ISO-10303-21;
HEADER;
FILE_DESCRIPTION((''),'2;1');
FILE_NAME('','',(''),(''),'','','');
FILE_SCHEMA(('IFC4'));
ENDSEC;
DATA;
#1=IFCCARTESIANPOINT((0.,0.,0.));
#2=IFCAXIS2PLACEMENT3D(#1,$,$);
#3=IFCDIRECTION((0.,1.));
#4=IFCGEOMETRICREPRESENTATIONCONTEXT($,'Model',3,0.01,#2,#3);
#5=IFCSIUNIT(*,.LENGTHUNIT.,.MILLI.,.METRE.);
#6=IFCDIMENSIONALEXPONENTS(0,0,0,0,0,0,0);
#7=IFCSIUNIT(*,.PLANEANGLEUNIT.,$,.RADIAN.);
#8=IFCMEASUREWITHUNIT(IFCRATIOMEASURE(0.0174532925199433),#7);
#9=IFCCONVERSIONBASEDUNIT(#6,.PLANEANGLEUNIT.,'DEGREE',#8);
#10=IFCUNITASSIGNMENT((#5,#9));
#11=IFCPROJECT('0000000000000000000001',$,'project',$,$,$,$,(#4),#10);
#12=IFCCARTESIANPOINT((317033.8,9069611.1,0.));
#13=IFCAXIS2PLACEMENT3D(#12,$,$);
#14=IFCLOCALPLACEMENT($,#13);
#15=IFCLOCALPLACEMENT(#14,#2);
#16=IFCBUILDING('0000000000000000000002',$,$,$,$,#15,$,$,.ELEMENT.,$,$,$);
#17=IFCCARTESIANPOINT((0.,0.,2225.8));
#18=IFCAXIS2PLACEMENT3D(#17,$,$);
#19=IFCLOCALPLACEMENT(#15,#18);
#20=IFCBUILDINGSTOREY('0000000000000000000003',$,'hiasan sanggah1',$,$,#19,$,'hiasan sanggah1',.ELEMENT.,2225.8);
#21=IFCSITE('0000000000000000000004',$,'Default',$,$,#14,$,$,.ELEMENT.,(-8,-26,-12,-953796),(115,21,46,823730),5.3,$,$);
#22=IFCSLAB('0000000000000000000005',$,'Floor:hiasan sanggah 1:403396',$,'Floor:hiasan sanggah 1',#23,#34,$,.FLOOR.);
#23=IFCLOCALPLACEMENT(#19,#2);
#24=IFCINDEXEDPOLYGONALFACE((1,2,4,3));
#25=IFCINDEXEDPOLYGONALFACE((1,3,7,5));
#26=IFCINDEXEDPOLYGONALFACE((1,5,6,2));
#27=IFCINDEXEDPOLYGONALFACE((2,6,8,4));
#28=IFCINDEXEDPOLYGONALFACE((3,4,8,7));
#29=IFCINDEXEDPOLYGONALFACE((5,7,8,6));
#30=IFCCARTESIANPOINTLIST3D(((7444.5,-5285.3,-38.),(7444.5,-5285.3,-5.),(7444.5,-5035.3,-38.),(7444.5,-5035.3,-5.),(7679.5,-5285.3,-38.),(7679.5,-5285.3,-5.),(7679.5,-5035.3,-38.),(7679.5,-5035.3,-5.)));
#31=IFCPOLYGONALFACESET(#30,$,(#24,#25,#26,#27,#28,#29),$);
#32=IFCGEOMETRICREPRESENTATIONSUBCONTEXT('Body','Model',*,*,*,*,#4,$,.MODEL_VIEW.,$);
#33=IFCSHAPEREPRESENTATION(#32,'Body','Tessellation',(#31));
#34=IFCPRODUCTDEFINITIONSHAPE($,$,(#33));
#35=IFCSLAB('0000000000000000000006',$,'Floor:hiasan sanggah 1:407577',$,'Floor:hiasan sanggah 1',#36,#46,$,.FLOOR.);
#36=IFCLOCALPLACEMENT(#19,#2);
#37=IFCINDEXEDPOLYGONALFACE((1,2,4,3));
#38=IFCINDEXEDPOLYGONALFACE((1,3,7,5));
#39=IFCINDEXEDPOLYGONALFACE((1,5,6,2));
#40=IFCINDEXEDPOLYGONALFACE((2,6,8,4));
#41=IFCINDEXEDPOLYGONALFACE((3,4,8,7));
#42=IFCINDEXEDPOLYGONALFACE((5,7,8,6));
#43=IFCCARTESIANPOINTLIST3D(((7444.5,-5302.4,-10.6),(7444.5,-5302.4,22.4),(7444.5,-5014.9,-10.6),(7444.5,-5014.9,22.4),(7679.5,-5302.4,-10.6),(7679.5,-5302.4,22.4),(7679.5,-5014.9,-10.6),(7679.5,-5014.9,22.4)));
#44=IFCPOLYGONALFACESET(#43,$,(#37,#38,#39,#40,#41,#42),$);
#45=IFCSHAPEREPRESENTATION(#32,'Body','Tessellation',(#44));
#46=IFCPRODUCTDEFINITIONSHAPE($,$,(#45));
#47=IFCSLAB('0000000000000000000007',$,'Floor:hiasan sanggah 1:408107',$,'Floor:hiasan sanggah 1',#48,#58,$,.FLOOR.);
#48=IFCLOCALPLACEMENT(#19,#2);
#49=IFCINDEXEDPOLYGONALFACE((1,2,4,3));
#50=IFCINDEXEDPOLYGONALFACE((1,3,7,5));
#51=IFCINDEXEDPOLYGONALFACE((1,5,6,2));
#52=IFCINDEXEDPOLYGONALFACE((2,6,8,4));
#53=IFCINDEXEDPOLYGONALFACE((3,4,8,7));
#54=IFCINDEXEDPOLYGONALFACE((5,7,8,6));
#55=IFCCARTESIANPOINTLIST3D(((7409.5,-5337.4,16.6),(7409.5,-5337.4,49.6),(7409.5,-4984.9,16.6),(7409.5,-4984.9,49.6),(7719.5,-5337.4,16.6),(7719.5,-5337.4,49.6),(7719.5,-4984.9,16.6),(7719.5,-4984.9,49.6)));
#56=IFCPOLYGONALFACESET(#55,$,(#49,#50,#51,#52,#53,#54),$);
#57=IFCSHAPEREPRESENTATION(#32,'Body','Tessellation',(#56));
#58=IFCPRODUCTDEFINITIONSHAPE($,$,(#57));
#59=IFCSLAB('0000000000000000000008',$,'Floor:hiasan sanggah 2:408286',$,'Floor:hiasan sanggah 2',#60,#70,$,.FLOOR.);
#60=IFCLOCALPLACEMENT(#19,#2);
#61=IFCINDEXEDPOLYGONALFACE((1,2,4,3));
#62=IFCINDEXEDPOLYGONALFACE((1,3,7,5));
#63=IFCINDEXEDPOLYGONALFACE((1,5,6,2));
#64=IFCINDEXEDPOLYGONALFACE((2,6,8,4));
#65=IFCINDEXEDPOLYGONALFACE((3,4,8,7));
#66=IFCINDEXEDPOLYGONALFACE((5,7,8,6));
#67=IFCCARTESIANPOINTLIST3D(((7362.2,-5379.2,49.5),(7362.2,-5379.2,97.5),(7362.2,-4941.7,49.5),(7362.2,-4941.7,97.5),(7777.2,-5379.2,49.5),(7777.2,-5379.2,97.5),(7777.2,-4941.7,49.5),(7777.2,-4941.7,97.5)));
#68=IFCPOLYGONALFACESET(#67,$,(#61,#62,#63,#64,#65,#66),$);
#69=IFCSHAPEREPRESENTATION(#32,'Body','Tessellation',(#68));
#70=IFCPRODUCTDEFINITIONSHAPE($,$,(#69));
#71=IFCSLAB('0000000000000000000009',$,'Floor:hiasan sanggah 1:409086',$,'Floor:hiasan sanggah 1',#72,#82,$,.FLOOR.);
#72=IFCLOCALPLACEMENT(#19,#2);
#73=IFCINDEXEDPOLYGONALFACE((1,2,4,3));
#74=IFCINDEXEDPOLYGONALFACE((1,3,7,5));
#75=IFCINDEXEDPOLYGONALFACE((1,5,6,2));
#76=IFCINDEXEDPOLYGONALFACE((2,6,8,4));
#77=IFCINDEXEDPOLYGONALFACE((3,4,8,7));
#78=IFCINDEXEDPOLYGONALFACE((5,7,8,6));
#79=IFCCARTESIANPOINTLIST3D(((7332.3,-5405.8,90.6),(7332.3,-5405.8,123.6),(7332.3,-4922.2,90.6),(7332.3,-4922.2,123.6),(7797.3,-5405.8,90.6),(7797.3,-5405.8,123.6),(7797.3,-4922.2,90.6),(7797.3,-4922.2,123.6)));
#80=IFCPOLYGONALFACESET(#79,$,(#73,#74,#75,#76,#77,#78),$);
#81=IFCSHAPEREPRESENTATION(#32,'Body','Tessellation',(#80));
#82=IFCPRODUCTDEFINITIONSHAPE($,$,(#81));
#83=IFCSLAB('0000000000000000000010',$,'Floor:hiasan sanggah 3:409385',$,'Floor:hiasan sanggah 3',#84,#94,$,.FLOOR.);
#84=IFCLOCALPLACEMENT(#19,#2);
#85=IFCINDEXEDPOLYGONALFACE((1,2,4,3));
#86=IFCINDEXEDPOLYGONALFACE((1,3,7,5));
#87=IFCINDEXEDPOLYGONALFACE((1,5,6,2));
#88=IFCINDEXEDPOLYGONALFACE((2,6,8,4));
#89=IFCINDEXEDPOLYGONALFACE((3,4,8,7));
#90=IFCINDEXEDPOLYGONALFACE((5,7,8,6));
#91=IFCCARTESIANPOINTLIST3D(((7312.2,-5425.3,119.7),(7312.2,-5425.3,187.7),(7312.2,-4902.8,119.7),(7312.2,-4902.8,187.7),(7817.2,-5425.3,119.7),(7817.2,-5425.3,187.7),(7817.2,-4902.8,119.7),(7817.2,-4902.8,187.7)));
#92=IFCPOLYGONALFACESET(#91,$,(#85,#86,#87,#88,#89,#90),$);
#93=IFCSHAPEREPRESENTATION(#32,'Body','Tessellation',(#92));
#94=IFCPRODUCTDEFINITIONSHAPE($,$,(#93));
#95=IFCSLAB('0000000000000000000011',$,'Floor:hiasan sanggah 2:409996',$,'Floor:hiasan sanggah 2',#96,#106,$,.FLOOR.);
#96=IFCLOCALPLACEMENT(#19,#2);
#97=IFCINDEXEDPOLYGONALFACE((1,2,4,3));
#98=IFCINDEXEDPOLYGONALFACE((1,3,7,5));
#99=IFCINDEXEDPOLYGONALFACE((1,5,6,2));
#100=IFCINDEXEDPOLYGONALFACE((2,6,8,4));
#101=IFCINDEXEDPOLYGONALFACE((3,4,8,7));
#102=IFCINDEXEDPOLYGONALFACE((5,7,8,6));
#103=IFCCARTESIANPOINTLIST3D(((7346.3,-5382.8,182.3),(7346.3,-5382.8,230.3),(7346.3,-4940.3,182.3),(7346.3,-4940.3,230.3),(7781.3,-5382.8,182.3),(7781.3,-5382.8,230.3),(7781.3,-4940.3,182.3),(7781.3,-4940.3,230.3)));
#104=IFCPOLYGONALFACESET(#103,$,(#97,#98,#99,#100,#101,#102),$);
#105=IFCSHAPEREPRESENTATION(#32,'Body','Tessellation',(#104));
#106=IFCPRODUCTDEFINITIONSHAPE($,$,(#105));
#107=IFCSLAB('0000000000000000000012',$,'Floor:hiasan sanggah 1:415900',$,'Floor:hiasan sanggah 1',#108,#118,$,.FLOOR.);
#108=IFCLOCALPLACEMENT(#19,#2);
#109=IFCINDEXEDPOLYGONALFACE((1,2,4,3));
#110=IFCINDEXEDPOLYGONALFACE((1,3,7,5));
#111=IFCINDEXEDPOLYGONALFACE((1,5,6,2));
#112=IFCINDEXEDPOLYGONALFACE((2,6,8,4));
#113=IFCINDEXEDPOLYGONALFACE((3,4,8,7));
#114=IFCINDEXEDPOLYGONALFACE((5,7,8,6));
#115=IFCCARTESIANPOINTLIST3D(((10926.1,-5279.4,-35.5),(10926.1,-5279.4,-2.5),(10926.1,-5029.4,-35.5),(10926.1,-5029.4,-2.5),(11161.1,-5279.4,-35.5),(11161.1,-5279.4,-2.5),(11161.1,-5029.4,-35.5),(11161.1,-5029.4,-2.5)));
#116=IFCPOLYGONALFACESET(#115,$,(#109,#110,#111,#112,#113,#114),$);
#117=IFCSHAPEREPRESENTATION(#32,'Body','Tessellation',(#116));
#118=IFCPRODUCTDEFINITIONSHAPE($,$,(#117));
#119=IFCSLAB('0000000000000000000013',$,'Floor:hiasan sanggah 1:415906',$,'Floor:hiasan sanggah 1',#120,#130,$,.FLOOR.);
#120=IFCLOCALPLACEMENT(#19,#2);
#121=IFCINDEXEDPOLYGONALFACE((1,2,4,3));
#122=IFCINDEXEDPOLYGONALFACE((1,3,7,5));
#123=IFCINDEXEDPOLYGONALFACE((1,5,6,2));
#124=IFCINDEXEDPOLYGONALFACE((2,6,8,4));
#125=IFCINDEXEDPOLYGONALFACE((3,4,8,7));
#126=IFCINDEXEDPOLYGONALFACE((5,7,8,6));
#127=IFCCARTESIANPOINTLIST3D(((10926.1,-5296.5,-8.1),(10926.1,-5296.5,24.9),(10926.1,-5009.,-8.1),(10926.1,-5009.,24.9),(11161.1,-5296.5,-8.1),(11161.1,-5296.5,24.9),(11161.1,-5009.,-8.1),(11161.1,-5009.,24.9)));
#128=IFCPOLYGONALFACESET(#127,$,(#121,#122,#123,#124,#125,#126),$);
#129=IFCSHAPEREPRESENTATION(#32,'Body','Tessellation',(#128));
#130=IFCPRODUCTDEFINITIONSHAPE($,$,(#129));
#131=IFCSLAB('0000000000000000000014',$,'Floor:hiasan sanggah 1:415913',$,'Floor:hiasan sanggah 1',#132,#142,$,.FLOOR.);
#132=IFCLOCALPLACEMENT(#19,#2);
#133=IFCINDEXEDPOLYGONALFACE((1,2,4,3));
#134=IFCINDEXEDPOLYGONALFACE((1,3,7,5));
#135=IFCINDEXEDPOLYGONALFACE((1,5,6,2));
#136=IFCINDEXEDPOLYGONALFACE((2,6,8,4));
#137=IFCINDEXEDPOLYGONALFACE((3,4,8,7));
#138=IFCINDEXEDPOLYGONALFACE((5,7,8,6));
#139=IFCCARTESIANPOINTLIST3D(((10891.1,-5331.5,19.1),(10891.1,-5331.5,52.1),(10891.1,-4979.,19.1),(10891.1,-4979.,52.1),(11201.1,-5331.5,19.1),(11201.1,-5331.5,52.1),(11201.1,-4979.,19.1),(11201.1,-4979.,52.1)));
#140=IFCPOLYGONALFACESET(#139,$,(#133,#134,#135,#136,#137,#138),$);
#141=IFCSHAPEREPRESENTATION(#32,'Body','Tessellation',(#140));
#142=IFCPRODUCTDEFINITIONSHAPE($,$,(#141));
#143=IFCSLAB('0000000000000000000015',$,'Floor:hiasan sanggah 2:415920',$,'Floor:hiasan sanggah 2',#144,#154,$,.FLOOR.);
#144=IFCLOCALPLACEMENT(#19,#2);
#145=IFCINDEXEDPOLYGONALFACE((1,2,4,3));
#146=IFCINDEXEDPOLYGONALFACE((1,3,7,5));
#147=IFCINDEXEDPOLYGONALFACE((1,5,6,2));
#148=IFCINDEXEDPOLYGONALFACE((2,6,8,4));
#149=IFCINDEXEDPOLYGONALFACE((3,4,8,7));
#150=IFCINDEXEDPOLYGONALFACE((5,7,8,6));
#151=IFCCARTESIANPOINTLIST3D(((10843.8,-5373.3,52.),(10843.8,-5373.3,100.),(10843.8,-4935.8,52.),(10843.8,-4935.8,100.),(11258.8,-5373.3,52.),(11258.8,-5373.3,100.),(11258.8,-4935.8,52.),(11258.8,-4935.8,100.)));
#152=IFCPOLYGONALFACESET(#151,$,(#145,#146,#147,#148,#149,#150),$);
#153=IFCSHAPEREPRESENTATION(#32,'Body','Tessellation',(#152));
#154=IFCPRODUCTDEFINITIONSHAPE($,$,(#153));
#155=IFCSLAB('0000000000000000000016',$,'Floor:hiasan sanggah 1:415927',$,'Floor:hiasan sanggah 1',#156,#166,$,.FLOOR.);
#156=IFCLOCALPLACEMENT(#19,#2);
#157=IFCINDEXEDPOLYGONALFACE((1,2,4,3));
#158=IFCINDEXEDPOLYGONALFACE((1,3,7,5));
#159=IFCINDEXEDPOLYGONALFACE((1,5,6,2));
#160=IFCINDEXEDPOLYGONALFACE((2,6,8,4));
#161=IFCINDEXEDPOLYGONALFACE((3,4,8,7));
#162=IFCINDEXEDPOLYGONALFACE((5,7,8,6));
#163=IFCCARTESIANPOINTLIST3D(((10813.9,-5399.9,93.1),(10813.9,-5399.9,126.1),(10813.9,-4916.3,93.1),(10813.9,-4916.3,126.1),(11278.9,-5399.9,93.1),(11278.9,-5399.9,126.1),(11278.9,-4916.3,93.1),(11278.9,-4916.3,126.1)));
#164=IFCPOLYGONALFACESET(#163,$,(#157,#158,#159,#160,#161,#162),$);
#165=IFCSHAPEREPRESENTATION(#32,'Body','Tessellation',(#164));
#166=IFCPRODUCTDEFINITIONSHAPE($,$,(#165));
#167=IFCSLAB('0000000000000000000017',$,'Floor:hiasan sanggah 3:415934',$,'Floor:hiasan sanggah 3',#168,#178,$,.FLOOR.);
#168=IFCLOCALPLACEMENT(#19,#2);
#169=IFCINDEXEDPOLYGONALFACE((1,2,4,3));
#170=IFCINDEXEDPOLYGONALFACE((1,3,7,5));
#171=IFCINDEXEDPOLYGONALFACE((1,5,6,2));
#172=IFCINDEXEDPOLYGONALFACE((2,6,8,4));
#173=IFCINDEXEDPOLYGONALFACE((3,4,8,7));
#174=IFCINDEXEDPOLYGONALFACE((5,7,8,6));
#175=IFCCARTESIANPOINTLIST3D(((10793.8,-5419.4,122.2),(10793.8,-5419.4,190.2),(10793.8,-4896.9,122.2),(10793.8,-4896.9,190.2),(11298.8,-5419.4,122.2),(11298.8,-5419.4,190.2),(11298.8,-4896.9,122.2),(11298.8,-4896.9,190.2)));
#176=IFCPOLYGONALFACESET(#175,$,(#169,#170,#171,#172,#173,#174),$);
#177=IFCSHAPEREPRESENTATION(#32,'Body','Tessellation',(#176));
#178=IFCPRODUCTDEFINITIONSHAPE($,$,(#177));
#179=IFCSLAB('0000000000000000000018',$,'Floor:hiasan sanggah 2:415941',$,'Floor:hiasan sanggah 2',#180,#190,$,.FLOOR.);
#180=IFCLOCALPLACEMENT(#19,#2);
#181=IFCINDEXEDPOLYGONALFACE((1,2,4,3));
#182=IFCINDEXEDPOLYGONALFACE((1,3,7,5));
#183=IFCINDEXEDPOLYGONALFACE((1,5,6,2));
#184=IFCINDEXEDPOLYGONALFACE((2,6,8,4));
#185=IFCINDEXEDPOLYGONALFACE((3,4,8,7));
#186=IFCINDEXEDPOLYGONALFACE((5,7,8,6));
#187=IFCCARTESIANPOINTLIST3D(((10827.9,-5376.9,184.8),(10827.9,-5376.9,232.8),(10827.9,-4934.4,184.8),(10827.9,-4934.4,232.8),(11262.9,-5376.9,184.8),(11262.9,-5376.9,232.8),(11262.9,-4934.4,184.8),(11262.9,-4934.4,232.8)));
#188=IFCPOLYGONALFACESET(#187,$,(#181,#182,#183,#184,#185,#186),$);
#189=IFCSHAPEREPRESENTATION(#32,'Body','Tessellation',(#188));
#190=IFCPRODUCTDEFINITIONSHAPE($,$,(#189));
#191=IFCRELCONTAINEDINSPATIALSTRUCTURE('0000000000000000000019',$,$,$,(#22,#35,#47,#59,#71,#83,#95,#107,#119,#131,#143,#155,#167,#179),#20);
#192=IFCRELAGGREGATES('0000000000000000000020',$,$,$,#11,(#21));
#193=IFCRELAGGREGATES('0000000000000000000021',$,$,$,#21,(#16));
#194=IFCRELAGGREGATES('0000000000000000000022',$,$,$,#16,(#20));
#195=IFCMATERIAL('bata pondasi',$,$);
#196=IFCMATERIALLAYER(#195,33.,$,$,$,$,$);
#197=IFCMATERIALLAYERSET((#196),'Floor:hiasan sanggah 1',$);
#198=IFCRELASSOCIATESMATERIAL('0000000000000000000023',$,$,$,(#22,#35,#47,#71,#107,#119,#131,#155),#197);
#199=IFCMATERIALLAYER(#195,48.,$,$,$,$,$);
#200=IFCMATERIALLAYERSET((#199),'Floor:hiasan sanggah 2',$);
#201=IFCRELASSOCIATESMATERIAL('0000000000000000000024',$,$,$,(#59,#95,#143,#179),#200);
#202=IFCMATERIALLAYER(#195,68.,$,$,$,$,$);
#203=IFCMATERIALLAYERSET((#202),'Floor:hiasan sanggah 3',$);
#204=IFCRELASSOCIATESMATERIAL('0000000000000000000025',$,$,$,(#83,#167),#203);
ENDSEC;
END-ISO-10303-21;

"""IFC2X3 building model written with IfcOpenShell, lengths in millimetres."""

from ifc_helpers import new_model, entity, si_unit, converted_unit, direction, frame, frame_2d, origin, origin_2d_with_axis, place, context, subcontext, project, spatial, rectangle, extrude, material, layer, layer_set, layer_usage, element, save


model = new_model("IFC2X3")

# Units and contexts
model_context = context("Model", 3, precision=0.01, world=origin(), true_north=direction((0.0, 1.0)))
body_context = subcontext(model_context, "Body", "Model", "MODEL_VIEW")
ifc_project = project(units=[si_unit("LENGTHUNIT", "METRE", prefix="MILLI"), converted_unit("PLANEANGLEUNIT", "DEGREE", entity("IfcRatioMeasure", 0.0174532925199433), si_unit("PLANEANGLEUNIT", "RADIAN"), dimensions=[0, 0, 0, 0, 0, 0, 0])], contexts=[model_context])

# Site, building, storey
site_placement = place(None, frame((317033.8, 9069611.1, 0.0)))
site = spatial("IfcSite", under=ifc_project, at=site_placement, Name="Default", CompositionType="ELEMENT", RefLatitude=(-8, -26, -12, -953796), RefLongitude=(115, 21, 46, 823730), RefElevation=5.3)
building_placement = place(site_placement, origin())
building = spatial("IfcBuilding", under=site, at=building_placement, CompositionType="ELEMENT")
storey_placement = place(building_placement, frame((0.0, 0.0, 2225.8)))
storey = spatial("IfcBuildingStorey", under=building, at=storey_placement, Name="hiasan sanggah1", LongName="hiasan sanggah1", CompositionType="ELEMENT", Elevation=2225.8)

# Slabs
ifc_material = material(Name="bata pondasi")
ifc_layer_1 = layer(ifc_material, 33.0)
ifc_layer_set_1 = layer_set([ifc_layer_1], Name="Floor:hiasan sanggah 1")
ifc_layer_usage_1 = layer_usage(ifc_layer_set_1, "AXIS3", "POSITIVE", 0.0)
slab_1_placement = place(storey_placement, origin())
element("IfcSlab", 1, at=slab_1_placement, inside=storey, material=ifc_layer_usage_1, Name="Floor:hiasan sanggah 1:403396", ObjectType="Floor:hiasan sanggah 1", PredefinedType="FLOOR", context=body_context, shape_type="SweptSolid", body=[
    extrude(rectangle(XDim=250.0, YDim=235.0, at=frame_2d((0.0, 0.0), x_axis=(1.0, 0.0))), frame((7562.0, -5160.3, -5.0), z_axis=(0.0, 0.0, -1.0), x_axis=(0.0, 1.0, 0.0)), (0.0, 0.0, 1.0), 33.0),
])
ifc_layer_usage_2 = layer_usage(ifc_layer_set_1, "AXIS3", "POSITIVE", 0.0)
slab_2_placement = place(storey_placement, origin())
element("IfcSlab", 2, at=slab_2_placement, inside=storey, material=ifc_layer_usage_2, Name="Floor:hiasan sanggah 1:407577", ObjectType="Floor:hiasan sanggah 1", PredefinedType="FLOOR", context=body_context, shape_type="SweptSolid", body=[
    extrude(rectangle(XDim=287.5, YDim=235.0, at=frame_2d((0.0, 0.0), x_axis=(1.0, 0.0))), frame((7562.0, -5158.6, 22.4), z_axis=(0.0, 0.0, -1.0), x_axis=(0.0, 1.0, 0.0)), (0.0, 0.0, 1.0), 33.0),
])
ifc_layer_usage_3 = layer_usage(ifc_layer_set_1, "AXIS3", "POSITIVE", 0.0)
slab_3_placement = place(storey_placement, origin())
element("IfcSlab", 3, at=slab_3_placement, inside=storey, material=ifc_layer_usage_3, Name="Floor:hiasan sanggah 1:408107", ObjectType="Floor:hiasan sanggah 1", PredefinedType="FLOOR", context=body_context, shape_type="SweptSolid", body=[
    extrude(rectangle(XDim=352.5, YDim=310.0, at=origin_2d_with_axis()), frame((7564.5, -5161.1, 49.6), z_axis=(0.0, 0.0, -1.0), x_axis=(0.0, 1.0, 0.0)), (0.0, 0.0, 1.0), 33.0),
])
ifc_layer_2 = layer(ifc_material, 48.0)
ifc_layer_set_2 = layer_set([ifc_layer_2], Name="Floor:hiasan sanggah 2")
ifc_layer_usage_4 = layer_usage(ifc_layer_set_2, "AXIS3", "POSITIVE", 0.0)
slab_4_placement = place(storey_placement, origin())
element("IfcSlab", 4, at=slab_4_placement, inside=storey, material=ifc_layer_usage_4, Name="Floor:hiasan sanggah 2:408286", ObjectType="Floor:hiasan sanggah 2", PredefinedType="FLOOR", context=body_context, shape_type="SweptSolid", body=[
    extrude(rectangle(XDim=437.5, YDim=415.0, at=frame_2d((0.0, 0.0), x_axis=(1.0, 0.0))), frame((7569.7, -5160.5, 97.5), z_axis=(0.0, 0.0, -1.0), x_axis=(0.0, 1.0, 0.0)), (0.0, 0.0, 1.0), 48.0),
])
ifc_layer_usage_5 = layer_usage(ifc_layer_set_1, "AXIS3", "POSITIVE", 0.0)
slab_5_placement = place(storey_placement, origin())
element("IfcSlab", 5, at=slab_5_placement, inside=storey, material=ifc_layer_usage_5, Name="Floor:hiasan sanggah 1:409086", ObjectType="Floor:hiasan sanggah 1", PredefinedType="FLOOR", context=body_context, shape_type="SweptSolid", body=[
    extrude(rectangle(XDim=483.7, YDim=465.0, at=frame_2d((0.0, 0.0), x_axis=(1.0, 0.0))), frame((7564.8, -5164.0, 123.6), z_axis=(0.0, 0.0, -1.0), x_axis=(0.0, 1.0, 0.0)), (0.0, 0.0, 1.0), 33.0),
])
ifc_layer_3 = layer(ifc_material, 68.0)
ifc_layer_set_3 = layer_set([ifc_layer_3], Name="Floor:hiasan sanggah 3")
ifc_layer_usage_6 = layer_usage(ifc_layer_set_3, "AXIS3", "POSITIVE", 0.0)
slab_6_placement = place(storey_placement, origin())
element("IfcSlab", 6, at=slab_6_placement, inside=storey, material=ifc_layer_usage_6, Name="Floor:hiasan sanggah 3:409385", ObjectType="Floor:hiasan sanggah 3", PredefinedType="FLOOR", context=body_context, shape_type="SweptSolid", body=[
    extrude(rectangle(XDim=522.5, YDim=505.0, at=frame_2d((0.0, 0.0), x_axis=(1.0, 0.0))), frame((7564.7, -5164.0, 187.7), z_axis=(0.0, 0.0, -1.0), x_axis=(0.0, 1.0, 0.0)), (0.0, 0.0, 1.0), 68.0),
])
ifc_layer_usage_7 = layer_usage(ifc_layer_set_2, "AXIS3", "POSITIVE", 0.0)
slab_7_placement = place(storey_placement, origin())
element("IfcSlab", 7, at=slab_7_placement, inside=storey, material=ifc_layer_usage_7, Name="Floor:hiasan sanggah 2:409996", ObjectType="Floor:hiasan sanggah 2", PredefinedType="FLOOR", context=body_context, shape_type="SweptSolid", body=[
    extrude(rectangle(XDim=442.5, YDim=435.0, at=frame_2d((0.0, 0.0), x_axis=(1.0, 0.0))), frame((7563.8, -5161.5, 230.3), z_axis=(0.0, 0.0, -1.0), x_axis=(0.0, 1.0, 0.0)), (0.0, 0.0, 1.0), 48.0),
])
ifc_layer_usage_8 = layer_usage(ifc_layer_set_1, "AXIS3", "POSITIVE", 0.0)
slab_8_placement = place(storey_placement, origin())
element("IfcSlab", 8, at=slab_8_placement, inside=storey, material=ifc_layer_usage_8, Name="Floor:hiasan sanggah 1:415900", ObjectType="Floor:hiasan sanggah 1", PredefinedType="FLOOR", context=body_context, shape_type="SweptSolid", body=[
    extrude(rectangle(XDim=250.0, YDim=235.0, at=origin_2d_with_axis()), frame((11043.6, -5154.4, -2.5), z_axis=(0.0, 0.0, -1.0), x_axis=(0.0, 1.0, 0.0)), (0.0, 0.0, 1.0), 33.0),
])
ifc_layer_usage_9 = layer_usage(ifc_layer_set_1, "AXIS3", "POSITIVE", 0.0)
slab_9_placement = place(storey_placement, origin())
element("IfcSlab", 9, at=slab_9_placement, inside=storey, material=ifc_layer_usage_9, Name="Floor:hiasan sanggah 1:415906", ObjectType="Floor:hiasan sanggah 1", PredefinedType="FLOOR", context=body_context, shape_type="SweptSolid", body=[
    extrude(rectangle(XDim=287.5, YDim=235.0, at=frame_2d((0.0, 0.0), x_axis=(1.0, 0.0))), frame((11043.6, -5152.7, 24.9), z_axis=(0.0, 0.0, -1.0), x_axis=(0.0, 1.0, 0.0)), (0.0, 0.0, 1.0), 33.0),
])
ifc_layer_usage_10 = layer_usage(ifc_layer_set_1, "AXIS3", "POSITIVE", 0.0)
slab_10_placement = place(storey_placement, origin())
element("IfcSlab", 10, at=slab_10_placement, inside=storey, material=ifc_layer_usage_10, Name="Floor:hiasan sanggah 1:415913", ObjectType="Floor:hiasan sanggah 1", PredefinedType="FLOOR", context=body_context, shape_type="SweptSolid", body=[
    extrude(rectangle(XDim=352.5, YDim=310.0, at=frame_2d((0.0, 0.0), x_axis=(1.0, 0.0))), frame((11046.1, -5155.2, 52.1), z_axis=(0.0, 0.0, -1.0), x_axis=(0.0, 1.0, 0.0)), (0.0, 0.0, 1.0), 33.0),
])
ifc_layer_usage_11 = layer_usage(ifc_layer_set_2, "AXIS3", "POSITIVE", 0.0)
slab_11_placement = place(storey_placement, origin())
element("IfcSlab", 11, at=slab_11_placement, inside=storey, material=ifc_layer_usage_11, Name="Floor:hiasan sanggah 2:415920", ObjectType="Floor:hiasan sanggah 2", PredefinedType="FLOOR", context=body_context, shape_type="SweptSolid", body=[
    extrude(rectangle(XDim=437.5, YDim=415.0, at=frame_2d((0.0, 0.0), x_axis=(1.0, 0.0))), frame((11051.3, -5154.6, 100.0), z_axis=(0.0, 0.0, -1.0), x_axis=(0.0, 1.0, 0.0)), (0.0, 0.0, 1.0), 48.0),
])
ifc_layer_usage_12 = layer_usage(ifc_layer_set_1, "AXIS3", "POSITIVE", 0.0)
slab_12_placement = place(storey_placement, origin())
element("IfcSlab", 12, at=slab_12_placement, inside=storey, material=ifc_layer_usage_12, Name="Floor:hiasan sanggah 1:415927", ObjectType="Floor:hiasan sanggah 1", PredefinedType="FLOOR", context=body_context, shape_type="SweptSolid", body=[
    extrude(rectangle(XDim=483.7, YDim=465.0, at=origin_2d_with_axis()), frame((11046.4, -5158.1, 126.1), z_axis=(0.0, 0.0, -1.0), x_axis=(0.0, 1.0, 0.0)), (0.0, 0.0, 1.0), 33.0),
])
ifc_layer_usage_13 = layer_usage(ifc_layer_set_3, "AXIS3", "POSITIVE", 0.0)
slab_13_placement = place(storey_placement, origin())
element("IfcSlab", 13, at=slab_13_placement, inside=storey, material=ifc_layer_usage_13, Name="Floor:hiasan sanggah 3:415934", ObjectType="Floor:hiasan sanggah 3", PredefinedType="FLOOR", context=body_context, shape_type="SweptSolid", body=[
    extrude(rectangle(XDim=522.5, YDim=505.0, at=frame_2d((0.0, 0.0), x_axis=(1.0, 0.0))), frame((11046.3, -5158.1, 190.2), z_axis=(0.0, 0.0, -1.0), x_axis=(0.0, 1.0, 0.0)), (0.0, 0.0, 1.0), 68.0),
])
ifc_layer_usage_14 = layer_usage(ifc_layer_set_2, "AXIS3", "POSITIVE", 0.0)
slab_14_placement = place(storey_placement, origin())
element("IfcSlab", 14, at=slab_14_placement, inside=storey, material=ifc_layer_usage_14, Name="Floor:hiasan sanggah 2:415941", ObjectType="Floor:hiasan sanggah 2", PredefinedType="FLOOR", context=body_context, shape_type="SweptSolid", body=[
    extrude(rectangle(XDim=442.5, YDim=435.0, at=frame_2d((0.0, 0.0), x_axis=(1.0, 0.0))), frame((11045.4, -5155.6, 232.8), z_axis=(0.0, 0.0, -1.0), x_axis=(0.0, 1.0, 0.0)), (0.0, 0.0, 1.0), 48.0),
])

save(model, "model.ifc")
